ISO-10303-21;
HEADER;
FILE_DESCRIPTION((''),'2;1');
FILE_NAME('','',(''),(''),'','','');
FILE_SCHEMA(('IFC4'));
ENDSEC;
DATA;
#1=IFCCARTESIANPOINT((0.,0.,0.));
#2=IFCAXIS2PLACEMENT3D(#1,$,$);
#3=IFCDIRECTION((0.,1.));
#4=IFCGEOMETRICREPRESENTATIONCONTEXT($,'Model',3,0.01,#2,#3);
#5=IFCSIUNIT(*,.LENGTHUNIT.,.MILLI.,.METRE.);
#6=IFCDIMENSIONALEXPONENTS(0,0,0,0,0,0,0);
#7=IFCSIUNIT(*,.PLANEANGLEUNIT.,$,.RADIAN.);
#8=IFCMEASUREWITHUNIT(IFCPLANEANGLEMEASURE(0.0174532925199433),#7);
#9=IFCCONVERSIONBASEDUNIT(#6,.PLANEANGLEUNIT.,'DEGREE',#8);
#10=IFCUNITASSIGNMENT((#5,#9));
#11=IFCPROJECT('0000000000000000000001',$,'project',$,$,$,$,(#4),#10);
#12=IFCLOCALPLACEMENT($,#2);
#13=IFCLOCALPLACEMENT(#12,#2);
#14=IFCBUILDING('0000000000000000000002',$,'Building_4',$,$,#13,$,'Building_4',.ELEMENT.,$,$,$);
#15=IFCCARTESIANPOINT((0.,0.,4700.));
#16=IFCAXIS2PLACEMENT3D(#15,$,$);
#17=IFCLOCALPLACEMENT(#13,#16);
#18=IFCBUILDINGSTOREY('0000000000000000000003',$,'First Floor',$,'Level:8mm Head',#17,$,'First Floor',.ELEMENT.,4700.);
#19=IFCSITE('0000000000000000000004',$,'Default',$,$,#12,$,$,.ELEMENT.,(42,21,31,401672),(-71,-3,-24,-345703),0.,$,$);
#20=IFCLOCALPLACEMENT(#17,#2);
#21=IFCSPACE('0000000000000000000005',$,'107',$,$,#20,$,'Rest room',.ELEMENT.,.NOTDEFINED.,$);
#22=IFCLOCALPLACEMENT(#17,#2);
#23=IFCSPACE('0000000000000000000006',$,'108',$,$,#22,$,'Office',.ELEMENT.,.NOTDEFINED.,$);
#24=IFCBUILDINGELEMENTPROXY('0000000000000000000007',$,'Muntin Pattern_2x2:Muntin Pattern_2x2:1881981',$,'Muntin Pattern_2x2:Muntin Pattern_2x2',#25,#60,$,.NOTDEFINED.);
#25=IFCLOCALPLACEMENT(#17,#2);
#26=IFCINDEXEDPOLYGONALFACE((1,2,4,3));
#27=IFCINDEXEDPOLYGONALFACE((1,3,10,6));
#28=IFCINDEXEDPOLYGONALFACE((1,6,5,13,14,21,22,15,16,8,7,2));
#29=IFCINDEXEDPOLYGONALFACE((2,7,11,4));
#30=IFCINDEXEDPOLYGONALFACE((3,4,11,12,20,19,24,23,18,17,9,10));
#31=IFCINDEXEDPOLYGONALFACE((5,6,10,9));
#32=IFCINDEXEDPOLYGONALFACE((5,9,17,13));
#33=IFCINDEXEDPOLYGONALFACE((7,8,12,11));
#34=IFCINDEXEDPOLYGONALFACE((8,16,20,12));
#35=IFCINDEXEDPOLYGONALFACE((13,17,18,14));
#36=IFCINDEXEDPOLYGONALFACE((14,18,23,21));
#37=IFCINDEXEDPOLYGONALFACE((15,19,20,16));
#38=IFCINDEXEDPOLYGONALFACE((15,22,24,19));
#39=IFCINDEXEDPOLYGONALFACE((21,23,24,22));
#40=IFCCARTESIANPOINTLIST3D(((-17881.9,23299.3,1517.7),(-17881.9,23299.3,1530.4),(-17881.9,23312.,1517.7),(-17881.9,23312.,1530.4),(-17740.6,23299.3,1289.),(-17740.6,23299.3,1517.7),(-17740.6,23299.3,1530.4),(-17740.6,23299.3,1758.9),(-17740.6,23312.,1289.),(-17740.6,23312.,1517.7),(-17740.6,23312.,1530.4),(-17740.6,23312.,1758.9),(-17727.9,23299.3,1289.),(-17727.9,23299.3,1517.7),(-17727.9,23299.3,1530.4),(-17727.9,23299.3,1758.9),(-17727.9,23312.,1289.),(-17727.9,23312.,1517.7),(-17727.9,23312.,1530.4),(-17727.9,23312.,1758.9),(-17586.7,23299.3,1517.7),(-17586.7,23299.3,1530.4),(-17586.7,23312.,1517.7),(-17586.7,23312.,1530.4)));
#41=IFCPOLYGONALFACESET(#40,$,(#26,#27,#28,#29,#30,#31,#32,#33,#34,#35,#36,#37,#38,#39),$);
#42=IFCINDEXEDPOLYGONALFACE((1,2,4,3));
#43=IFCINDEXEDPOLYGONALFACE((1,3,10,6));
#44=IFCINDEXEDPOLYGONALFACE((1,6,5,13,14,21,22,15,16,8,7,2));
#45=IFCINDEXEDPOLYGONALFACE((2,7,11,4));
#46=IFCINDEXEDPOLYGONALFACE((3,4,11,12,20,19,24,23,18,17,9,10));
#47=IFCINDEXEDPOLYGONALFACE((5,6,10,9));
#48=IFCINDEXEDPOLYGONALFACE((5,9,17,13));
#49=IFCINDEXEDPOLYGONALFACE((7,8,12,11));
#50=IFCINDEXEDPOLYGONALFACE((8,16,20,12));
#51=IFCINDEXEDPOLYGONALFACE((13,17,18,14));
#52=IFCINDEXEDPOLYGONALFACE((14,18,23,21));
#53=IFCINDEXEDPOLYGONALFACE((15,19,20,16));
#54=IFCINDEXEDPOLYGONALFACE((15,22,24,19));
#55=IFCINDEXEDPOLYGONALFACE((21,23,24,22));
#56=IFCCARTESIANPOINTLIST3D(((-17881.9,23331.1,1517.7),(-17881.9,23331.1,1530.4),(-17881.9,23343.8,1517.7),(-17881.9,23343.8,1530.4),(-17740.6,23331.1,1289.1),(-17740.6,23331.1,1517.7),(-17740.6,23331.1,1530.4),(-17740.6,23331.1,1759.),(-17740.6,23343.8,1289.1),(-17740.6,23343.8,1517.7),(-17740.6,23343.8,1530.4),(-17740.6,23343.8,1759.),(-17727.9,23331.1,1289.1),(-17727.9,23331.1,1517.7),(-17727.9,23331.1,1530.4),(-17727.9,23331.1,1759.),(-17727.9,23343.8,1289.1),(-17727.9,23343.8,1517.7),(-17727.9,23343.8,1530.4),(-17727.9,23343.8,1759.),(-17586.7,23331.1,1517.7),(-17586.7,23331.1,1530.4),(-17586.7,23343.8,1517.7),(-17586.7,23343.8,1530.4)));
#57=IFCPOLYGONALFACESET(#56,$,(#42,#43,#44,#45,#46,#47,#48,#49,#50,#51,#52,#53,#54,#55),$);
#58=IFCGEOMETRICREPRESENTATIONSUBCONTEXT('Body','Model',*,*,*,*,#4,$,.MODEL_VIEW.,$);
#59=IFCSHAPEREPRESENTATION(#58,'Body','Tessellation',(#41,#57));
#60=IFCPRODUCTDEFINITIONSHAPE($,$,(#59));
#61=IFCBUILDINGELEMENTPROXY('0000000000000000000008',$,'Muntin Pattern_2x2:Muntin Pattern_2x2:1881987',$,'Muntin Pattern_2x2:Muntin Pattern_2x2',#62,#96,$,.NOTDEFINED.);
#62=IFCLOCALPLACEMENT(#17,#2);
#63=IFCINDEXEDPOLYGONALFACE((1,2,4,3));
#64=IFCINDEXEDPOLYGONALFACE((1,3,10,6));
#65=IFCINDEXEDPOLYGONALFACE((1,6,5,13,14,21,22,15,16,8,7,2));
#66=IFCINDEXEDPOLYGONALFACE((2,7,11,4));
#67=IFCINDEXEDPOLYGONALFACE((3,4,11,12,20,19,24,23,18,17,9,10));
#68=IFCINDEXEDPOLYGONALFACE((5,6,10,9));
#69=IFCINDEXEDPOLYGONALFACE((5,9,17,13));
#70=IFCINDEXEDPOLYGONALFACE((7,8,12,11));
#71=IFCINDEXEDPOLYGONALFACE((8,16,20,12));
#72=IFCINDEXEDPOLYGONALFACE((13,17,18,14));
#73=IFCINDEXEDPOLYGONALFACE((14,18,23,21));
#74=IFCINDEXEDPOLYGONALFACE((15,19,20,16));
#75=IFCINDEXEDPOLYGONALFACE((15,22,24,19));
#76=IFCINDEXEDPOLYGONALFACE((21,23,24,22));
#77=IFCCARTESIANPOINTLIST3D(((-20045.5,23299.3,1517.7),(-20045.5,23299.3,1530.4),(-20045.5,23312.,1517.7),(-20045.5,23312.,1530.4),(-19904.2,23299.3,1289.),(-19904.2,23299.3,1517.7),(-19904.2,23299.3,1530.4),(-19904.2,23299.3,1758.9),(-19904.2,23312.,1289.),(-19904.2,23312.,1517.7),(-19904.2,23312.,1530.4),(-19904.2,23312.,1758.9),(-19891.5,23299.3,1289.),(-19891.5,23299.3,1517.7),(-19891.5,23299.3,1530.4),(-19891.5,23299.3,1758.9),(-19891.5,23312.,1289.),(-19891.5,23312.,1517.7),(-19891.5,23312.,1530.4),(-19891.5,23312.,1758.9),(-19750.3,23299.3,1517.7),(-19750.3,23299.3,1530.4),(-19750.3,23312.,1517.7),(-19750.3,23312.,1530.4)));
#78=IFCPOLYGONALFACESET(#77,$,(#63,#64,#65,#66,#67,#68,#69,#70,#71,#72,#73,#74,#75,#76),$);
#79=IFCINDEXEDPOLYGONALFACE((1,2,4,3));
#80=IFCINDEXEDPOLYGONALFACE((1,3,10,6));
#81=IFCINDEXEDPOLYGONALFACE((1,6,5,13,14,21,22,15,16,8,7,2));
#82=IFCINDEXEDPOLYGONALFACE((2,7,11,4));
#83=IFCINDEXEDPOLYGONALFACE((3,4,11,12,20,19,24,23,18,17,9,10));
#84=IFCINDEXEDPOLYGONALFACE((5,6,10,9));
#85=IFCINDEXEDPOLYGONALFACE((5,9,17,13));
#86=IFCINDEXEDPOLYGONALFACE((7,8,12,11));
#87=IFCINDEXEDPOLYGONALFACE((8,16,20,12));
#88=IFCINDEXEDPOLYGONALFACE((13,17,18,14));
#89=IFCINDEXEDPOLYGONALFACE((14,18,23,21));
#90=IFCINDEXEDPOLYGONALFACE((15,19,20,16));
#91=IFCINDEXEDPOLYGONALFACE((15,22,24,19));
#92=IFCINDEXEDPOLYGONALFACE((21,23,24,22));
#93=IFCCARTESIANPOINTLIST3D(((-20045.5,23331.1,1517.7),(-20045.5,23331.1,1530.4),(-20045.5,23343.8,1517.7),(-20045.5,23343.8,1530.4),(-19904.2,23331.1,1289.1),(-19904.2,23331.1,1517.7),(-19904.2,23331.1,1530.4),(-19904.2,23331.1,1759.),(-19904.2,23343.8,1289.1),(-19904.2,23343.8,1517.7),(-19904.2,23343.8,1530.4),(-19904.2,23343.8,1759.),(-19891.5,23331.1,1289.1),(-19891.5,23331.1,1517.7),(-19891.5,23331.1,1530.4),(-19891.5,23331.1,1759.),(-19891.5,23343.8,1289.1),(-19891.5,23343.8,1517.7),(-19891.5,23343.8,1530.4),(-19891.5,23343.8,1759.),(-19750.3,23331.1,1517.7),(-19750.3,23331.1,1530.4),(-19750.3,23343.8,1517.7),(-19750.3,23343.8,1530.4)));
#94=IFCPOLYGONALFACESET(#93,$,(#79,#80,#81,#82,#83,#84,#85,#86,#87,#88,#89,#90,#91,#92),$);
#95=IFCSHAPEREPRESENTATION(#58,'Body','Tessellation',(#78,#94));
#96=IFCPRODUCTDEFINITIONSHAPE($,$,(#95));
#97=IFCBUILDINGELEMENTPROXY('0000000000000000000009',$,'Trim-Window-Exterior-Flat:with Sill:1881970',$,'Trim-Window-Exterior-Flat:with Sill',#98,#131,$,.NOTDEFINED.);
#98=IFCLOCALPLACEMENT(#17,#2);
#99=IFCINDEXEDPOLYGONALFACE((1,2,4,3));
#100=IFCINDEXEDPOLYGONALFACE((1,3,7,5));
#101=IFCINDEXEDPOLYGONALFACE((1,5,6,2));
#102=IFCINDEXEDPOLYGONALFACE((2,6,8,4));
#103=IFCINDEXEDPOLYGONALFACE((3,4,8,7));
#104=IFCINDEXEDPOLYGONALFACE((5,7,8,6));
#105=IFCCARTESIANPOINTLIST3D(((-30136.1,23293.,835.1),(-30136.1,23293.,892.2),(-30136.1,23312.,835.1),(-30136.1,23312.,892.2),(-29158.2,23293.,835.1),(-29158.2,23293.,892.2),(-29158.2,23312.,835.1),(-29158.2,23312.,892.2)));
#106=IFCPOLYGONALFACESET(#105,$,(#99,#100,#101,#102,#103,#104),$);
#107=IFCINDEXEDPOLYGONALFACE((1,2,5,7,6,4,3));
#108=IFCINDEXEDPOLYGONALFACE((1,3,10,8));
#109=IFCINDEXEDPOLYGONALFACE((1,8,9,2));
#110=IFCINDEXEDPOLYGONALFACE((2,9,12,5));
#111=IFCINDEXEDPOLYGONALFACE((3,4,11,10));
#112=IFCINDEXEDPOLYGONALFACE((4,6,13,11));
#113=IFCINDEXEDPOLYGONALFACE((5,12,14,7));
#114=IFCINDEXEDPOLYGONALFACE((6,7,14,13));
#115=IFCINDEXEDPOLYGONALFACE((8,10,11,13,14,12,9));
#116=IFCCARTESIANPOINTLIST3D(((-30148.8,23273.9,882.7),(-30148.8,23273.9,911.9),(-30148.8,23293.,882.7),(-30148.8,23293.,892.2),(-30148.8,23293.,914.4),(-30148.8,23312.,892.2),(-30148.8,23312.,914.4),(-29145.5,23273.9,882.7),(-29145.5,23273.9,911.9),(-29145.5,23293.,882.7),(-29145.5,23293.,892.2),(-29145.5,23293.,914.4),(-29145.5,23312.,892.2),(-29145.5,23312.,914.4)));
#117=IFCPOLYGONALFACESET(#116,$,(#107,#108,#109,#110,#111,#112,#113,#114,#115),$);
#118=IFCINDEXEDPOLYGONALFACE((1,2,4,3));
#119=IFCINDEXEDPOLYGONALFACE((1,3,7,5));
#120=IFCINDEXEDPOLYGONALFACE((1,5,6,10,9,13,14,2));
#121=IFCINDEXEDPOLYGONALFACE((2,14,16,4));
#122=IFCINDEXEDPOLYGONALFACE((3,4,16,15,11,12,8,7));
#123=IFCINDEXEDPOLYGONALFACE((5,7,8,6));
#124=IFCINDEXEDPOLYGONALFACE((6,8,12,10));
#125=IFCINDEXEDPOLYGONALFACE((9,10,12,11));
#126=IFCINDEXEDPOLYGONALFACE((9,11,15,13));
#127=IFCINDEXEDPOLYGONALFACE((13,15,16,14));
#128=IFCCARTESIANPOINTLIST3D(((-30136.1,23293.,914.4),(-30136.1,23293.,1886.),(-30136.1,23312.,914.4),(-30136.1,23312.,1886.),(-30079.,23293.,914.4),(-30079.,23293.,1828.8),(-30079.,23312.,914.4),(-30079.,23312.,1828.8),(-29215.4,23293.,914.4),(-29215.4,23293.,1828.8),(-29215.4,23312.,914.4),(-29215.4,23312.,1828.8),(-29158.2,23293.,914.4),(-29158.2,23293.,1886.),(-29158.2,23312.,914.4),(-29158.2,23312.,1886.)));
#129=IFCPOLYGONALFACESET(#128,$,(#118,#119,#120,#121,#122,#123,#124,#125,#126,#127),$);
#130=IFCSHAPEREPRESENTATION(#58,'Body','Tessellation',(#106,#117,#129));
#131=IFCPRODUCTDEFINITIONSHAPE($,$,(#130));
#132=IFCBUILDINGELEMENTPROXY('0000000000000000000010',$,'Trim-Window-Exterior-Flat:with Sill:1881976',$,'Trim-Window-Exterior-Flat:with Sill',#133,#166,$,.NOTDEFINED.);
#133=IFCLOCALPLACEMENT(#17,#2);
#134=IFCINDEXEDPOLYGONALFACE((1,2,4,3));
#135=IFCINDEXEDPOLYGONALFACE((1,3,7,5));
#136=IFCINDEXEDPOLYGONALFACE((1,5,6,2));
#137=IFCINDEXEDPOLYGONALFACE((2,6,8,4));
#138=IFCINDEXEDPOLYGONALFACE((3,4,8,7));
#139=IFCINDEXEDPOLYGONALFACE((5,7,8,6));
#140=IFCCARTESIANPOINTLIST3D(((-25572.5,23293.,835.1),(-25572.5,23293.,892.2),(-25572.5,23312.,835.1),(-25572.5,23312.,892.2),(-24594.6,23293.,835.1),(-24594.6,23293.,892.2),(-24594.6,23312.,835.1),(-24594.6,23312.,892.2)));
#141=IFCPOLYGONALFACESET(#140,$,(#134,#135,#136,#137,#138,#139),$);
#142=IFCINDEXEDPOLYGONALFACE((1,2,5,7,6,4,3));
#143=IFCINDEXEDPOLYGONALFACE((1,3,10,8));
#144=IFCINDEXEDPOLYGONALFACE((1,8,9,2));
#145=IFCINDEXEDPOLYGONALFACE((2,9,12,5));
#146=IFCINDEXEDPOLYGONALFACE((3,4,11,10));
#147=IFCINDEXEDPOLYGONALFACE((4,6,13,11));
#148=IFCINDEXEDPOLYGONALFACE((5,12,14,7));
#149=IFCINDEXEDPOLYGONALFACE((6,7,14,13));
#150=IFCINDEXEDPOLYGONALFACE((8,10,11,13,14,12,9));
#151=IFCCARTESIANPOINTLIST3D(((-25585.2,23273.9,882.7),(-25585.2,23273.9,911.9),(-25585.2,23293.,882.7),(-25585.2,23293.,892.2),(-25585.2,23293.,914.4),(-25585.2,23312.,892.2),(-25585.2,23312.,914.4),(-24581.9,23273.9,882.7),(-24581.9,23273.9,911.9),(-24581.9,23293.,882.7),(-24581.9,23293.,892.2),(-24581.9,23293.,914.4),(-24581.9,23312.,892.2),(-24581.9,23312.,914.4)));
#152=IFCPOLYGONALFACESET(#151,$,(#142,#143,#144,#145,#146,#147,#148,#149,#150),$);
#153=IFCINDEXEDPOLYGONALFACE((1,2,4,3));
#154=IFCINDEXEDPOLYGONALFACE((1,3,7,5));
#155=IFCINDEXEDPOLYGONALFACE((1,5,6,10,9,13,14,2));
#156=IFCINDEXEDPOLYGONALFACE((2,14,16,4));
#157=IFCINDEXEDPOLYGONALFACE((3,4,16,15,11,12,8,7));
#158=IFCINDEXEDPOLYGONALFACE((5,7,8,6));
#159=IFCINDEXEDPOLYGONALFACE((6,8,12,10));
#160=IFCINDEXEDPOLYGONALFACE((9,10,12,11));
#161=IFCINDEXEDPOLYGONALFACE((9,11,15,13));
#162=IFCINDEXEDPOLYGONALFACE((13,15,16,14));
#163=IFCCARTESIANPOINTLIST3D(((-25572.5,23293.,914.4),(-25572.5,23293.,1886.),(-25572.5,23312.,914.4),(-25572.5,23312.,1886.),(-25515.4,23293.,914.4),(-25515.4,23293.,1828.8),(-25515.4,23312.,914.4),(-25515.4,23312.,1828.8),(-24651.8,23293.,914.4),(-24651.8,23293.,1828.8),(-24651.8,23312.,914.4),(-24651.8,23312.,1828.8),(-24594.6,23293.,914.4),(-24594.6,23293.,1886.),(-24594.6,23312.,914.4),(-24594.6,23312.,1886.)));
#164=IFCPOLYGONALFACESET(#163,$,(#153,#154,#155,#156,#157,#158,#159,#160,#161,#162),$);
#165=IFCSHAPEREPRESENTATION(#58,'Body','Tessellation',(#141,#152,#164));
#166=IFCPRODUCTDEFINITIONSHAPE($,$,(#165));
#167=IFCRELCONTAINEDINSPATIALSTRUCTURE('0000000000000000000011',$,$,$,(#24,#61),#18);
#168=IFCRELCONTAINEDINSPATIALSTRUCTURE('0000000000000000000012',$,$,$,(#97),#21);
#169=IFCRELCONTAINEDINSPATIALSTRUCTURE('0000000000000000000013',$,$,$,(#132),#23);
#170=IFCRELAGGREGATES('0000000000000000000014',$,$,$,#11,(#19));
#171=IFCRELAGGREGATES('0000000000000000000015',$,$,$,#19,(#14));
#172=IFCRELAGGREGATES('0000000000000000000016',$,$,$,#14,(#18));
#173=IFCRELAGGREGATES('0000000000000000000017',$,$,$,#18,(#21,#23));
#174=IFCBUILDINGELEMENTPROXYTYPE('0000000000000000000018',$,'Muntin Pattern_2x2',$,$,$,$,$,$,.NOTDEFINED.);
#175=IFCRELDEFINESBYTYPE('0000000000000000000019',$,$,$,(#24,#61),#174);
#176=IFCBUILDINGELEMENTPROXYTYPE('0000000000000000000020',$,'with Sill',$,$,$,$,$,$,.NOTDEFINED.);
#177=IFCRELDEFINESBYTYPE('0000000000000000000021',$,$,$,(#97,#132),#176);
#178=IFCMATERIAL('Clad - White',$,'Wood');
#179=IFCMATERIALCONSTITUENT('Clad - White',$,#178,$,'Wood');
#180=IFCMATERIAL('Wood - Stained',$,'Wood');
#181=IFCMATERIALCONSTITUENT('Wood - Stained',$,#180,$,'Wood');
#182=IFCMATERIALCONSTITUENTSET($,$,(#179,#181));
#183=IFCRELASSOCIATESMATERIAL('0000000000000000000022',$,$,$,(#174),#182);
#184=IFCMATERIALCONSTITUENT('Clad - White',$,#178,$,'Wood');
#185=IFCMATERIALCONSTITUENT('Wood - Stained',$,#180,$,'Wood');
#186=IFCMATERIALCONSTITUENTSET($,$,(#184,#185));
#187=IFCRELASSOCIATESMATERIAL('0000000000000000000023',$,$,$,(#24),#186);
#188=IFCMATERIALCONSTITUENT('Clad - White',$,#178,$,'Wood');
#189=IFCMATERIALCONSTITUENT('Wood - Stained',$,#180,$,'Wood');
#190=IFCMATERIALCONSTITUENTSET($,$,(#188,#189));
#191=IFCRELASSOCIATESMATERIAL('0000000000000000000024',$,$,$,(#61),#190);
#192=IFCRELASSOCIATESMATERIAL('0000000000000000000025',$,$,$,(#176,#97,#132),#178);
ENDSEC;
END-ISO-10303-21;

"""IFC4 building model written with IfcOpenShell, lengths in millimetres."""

from ifc_helpers import new_model, entity, si_unit, converted_unit, direction, frame, origin, place, context, subcontext, project, spatial, indexed_curve, outline, extrude, source, transform, mapped, material, constituent, constituent_set, type_object, type_shapes, element, save


model = new_model("IFC4")

# Units and contexts
model_context = context("Model", 3, precision=0.01, world=origin(), true_north=direction((0.0, 1.0)))
body_context = subcontext(model_context, "Body", "Model", "MODEL_VIEW")
ifc_project = project(units=[si_unit("LENGTHUNIT", "METRE", prefix="MILLI"), converted_unit("PLANEANGLEUNIT", "DEGREE", entity("IfcPlaneAngleMeasure", 0.0174532925199433), si_unit("PLANEANGLEUNIT", "RADIAN"), dimensions=[0, 0, 0, 0, 0, 0, 0])], contexts=[model_context])

# Site, building, storey
site_placement = place(None, origin())
site = spatial("IfcSite", under=ifc_project, at=site_placement, Name="Default", CompositionType="ELEMENT", RefLatitude=(42, 21, 31, 401672), RefLongitude=(-71, -3, -24, -345703), RefElevation=0.0)
building_placement = place(site_placement, origin())
building = spatial("IfcBuilding", under=site, at=building_placement, Name="Building_4", LongName="Building_4", CompositionType="ELEMENT")
storey_placement = place(building_placement, frame((0.0, 0.0, 4700.0)))
storey = spatial("IfcBuildingStorey", under=building, at=storey_placement, Name="First Floor", ObjectType="Level:8mm Head", LongName="First Floor", CompositionType="ELEMENT", Elevation=4700.0)

# Building element proxies
ifc_material_1 = material(Name="Clad - White", Category="Wood")
ifc_material_2 = material(Name="Wood - Stained", Category="Wood")
ifc_constituent_1 = constituent(ifc_material_1, Name="Clad - White", Category="Wood")
ifc_constituent_2 = constituent(ifc_material_2, Name="Wood - Stained", Category="Wood")
ifc_constituent_set_1 = constituent_set(constituents=[ifc_constituent_1, ifc_constituent_2])
building_element_proxy_type_1 = type_object("IfcBuildingElementProxyType", Name="Muntin Pattern_2x2", PredefinedType="NOTDEFINED", material=ifc_constituent_set_1)
shared_shape_1 = source(origin(), body_context, "Body", "SweptSolid", [
    extrude(outline(indexed_curve([(6.4, -6.4), (234.9, -6.4), (234.9, 6.3), (6.4, 6.3), (6.4, 147.6), (-6.3, 147.6), (-6.3, 6.3), (-235.0, 6.3), (-235.0, -6.4), (-6.3, -6.4), (-6.3, -147.6), (6.4, -147.6), (6.4, -6.4)], self_intersect=False)), frame((0.0, -22.2, 234.9), z_axis=(0.0, 1.0, 0.0), x_axis=(0.0, 0.0, 1.0)), (0.0, 0.0, 1.0), 12.7),
    extrude(outline(indexed_curve([(6.4, -6.4), (235.0, -6.4), (235.0, 6.3), (6.4, 6.3), (6.4, 147.6), (-6.3, 147.6), (-6.3, 6.3), (-235.0, 6.3), (-235.0, -6.4), (-6.3, -6.4), (-6.3, -147.6), (6.4, -147.6), (6.4, -6.4)], self_intersect=False)), frame((0.0, 9.5, 235.0), z_axis=(0.0, 1.0, 0.0), x_axis=(0.0, 0.0, 1.0)), (0.0, 0.0, 1.0), 12.7),
])
type_shapes(building_element_proxy_type_1, [shared_shape_1])
ifc_constituent_3 = constituent(ifc_material_1, Name="Clad - White", Category="Wood")
ifc_constituent_4 = constituent(ifc_material_2, Name="Wood - Stained", Category="Wood")
ifc_constituent_set_2 = constituent_set(constituents=[ifc_constituent_3, ifc_constituent_4])
proxy_1_placement = place(storey_placement, frame((-17734.3, 23321.5, 1289.1)))
element("IfcBuildingElementProxy", 1, at=proxy_1_placement, inside=storey, type_object=building_element_proxy_type_1, material=ifc_constituent_set_2, Name="Muntin Pattern_2x2:Muntin Pattern_2x2:1881981", ObjectType="Muntin Pattern_2x2:Muntin Pattern_2x2", PredefinedType="NOTDEFINED", context=body_context, shape_type="MappedRepresentation", body=[
    mapped(shared_shape_1, transform((0.0, 0.0, 0.0), scale=1.0)),
])
ifc_constituent_5 = constituent(ifc_material_1, Name="Clad - White", Category="Wood")
ifc_constituent_6 = constituent(ifc_material_2, Name="Wood - Stained", Category="Wood")
ifc_constituent_set_3 = constituent_set(constituents=[ifc_constituent_5, ifc_constituent_6])
proxy_2_placement = place(storey_placement, frame((-19897.9, 23321.5, 1289.1)))
element("IfcBuildingElementProxy", 2, at=proxy_2_placement, inside=storey, type_object=building_element_proxy_type_1, material=ifc_constituent_set_3, Name="Muntin Pattern_2x2:Muntin Pattern_2x2:1881987", ObjectType="Muntin Pattern_2x2:Muntin Pattern_2x2", PredefinedType="NOTDEFINED", context=body_context, shape_type="MappedRepresentation", body=[
    mapped(shared_shape_1, transform((0.0, 0.0, 0.0), scale=1.0)),
])

# Shared definitions
space_1_placement = place(storey_placement, origin())
space_1 = spatial("IfcSpace", under=storey, at=space_1_placement, Name="107", LongName="Rest room", CompositionType="ELEMENT", PredefinedType="NOTDEFINED")

# Building element proxy
building_element_proxy_type_2 = type_object("IfcBuildingElementProxyType", Name="with Sill", PredefinedType="NOTDEFINED", material=ifc_material_1)
shared_shape_2 = source(origin(), body_context, "Body", "SweptSolid", [
    extrude(outline(indexed_curve([(-488.9, -28.6), (488.9, -28.6), (488.9, 28.6), (-488.9, 28.6), (-488.9, -28.6)], self_intersect=False)), frame((0.0, -965.2, 0.0), z_axis=(0.0, 0.0, 1.0), x_axis=(-1.0, 0.0, 0.0)), (0.0, 0.0, 1.0), 19.1),
    extrude(outline(indexed_curve([(-19.0, -16.0), (0.0, -16.0), (0.0, -6.4), (19.0, -6.4), (19.0, 15.8), (0.0, 15.8), (-19.0, 13.3), (-19.0, -16.0)], self_intersect=False)), frame((-501.6, -930.2, 19.0), z_axis=(1.0, 0.0, 0.0), x_axis=(0.0, 0.0, -1.0)), (0.0, 0.0, 1.0), 1003.3),
    extrude(outline(indexed_curve([(-500.1, -488.9), (471.5, -488.9), (471.5, -431.8), (-442.9, -431.8), (-442.9, 431.8), (471.5, 431.8), (471.5, 488.9), (-500.1, 488.9), (-500.1, -488.9)], self_intersect=False)), frame((0.0, -442.9, 0.0), z_axis=(0.0, 0.0, 1.0), x_axis=(0.0, -1.0, 0.0)), (0.0, 0.0, 1.0), 19.1),
])
type_shapes(building_element_proxy_type_2, [shared_shape_2])
proxy_3_placement = place(space_1_placement, frame((-29647.2, 23312.0, 1828.8), z_axis=(0.0, -1.0, 0.0), x_axis=(1.0, 0.0, 0.0)))
element("IfcBuildingElementProxy", 3, at=proxy_3_placement, inside=space_1, type_object=building_element_proxy_type_2, material=ifc_material_1, Name="Trim-Window-Exterior-Flat:with Sill:1881970", ObjectType="Trim-Window-Exterior-Flat:with Sill", PredefinedType="NOTDEFINED", context=body_context, shape_type="MappedRepresentation", body=[
    mapped(shared_shape_2, transform((0.0, 0.0, 0.0), scale=1.0)),
])

# Shared definitions
space_2_placement = place(storey_placement, origin())
space_2 = spatial("IfcSpace", under=storey, at=space_2_placement, Name="108", LongName="Office", CompositionType="ELEMENT", PredefinedType="NOTDEFINED")

# Building element proxy
proxy_4_placement = place(space_2_placement, frame((-25083.6, 23312.0, 1828.8), z_axis=(0.0, -1.0, 0.0), x_axis=(1.0, 0.0, 0.0)))
element("IfcBuildingElementProxy", 4, at=proxy_4_placement, inside=space_2, type_object=building_element_proxy_type_2, material=ifc_material_1, Name="Trim-Window-Exterior-Flat:with Sill:1881976", ObjectType="Trim-Window-Exterior-Flat:with Sill", PredefinedType="NOTDEFINED", context=body_context, shape_type="MappedRepresentation", body=[
    mapped(shared_shape_2, transform((0.0, 0.0, 0.0), scale=1.0)),
])

save(model, "model.ifc")
